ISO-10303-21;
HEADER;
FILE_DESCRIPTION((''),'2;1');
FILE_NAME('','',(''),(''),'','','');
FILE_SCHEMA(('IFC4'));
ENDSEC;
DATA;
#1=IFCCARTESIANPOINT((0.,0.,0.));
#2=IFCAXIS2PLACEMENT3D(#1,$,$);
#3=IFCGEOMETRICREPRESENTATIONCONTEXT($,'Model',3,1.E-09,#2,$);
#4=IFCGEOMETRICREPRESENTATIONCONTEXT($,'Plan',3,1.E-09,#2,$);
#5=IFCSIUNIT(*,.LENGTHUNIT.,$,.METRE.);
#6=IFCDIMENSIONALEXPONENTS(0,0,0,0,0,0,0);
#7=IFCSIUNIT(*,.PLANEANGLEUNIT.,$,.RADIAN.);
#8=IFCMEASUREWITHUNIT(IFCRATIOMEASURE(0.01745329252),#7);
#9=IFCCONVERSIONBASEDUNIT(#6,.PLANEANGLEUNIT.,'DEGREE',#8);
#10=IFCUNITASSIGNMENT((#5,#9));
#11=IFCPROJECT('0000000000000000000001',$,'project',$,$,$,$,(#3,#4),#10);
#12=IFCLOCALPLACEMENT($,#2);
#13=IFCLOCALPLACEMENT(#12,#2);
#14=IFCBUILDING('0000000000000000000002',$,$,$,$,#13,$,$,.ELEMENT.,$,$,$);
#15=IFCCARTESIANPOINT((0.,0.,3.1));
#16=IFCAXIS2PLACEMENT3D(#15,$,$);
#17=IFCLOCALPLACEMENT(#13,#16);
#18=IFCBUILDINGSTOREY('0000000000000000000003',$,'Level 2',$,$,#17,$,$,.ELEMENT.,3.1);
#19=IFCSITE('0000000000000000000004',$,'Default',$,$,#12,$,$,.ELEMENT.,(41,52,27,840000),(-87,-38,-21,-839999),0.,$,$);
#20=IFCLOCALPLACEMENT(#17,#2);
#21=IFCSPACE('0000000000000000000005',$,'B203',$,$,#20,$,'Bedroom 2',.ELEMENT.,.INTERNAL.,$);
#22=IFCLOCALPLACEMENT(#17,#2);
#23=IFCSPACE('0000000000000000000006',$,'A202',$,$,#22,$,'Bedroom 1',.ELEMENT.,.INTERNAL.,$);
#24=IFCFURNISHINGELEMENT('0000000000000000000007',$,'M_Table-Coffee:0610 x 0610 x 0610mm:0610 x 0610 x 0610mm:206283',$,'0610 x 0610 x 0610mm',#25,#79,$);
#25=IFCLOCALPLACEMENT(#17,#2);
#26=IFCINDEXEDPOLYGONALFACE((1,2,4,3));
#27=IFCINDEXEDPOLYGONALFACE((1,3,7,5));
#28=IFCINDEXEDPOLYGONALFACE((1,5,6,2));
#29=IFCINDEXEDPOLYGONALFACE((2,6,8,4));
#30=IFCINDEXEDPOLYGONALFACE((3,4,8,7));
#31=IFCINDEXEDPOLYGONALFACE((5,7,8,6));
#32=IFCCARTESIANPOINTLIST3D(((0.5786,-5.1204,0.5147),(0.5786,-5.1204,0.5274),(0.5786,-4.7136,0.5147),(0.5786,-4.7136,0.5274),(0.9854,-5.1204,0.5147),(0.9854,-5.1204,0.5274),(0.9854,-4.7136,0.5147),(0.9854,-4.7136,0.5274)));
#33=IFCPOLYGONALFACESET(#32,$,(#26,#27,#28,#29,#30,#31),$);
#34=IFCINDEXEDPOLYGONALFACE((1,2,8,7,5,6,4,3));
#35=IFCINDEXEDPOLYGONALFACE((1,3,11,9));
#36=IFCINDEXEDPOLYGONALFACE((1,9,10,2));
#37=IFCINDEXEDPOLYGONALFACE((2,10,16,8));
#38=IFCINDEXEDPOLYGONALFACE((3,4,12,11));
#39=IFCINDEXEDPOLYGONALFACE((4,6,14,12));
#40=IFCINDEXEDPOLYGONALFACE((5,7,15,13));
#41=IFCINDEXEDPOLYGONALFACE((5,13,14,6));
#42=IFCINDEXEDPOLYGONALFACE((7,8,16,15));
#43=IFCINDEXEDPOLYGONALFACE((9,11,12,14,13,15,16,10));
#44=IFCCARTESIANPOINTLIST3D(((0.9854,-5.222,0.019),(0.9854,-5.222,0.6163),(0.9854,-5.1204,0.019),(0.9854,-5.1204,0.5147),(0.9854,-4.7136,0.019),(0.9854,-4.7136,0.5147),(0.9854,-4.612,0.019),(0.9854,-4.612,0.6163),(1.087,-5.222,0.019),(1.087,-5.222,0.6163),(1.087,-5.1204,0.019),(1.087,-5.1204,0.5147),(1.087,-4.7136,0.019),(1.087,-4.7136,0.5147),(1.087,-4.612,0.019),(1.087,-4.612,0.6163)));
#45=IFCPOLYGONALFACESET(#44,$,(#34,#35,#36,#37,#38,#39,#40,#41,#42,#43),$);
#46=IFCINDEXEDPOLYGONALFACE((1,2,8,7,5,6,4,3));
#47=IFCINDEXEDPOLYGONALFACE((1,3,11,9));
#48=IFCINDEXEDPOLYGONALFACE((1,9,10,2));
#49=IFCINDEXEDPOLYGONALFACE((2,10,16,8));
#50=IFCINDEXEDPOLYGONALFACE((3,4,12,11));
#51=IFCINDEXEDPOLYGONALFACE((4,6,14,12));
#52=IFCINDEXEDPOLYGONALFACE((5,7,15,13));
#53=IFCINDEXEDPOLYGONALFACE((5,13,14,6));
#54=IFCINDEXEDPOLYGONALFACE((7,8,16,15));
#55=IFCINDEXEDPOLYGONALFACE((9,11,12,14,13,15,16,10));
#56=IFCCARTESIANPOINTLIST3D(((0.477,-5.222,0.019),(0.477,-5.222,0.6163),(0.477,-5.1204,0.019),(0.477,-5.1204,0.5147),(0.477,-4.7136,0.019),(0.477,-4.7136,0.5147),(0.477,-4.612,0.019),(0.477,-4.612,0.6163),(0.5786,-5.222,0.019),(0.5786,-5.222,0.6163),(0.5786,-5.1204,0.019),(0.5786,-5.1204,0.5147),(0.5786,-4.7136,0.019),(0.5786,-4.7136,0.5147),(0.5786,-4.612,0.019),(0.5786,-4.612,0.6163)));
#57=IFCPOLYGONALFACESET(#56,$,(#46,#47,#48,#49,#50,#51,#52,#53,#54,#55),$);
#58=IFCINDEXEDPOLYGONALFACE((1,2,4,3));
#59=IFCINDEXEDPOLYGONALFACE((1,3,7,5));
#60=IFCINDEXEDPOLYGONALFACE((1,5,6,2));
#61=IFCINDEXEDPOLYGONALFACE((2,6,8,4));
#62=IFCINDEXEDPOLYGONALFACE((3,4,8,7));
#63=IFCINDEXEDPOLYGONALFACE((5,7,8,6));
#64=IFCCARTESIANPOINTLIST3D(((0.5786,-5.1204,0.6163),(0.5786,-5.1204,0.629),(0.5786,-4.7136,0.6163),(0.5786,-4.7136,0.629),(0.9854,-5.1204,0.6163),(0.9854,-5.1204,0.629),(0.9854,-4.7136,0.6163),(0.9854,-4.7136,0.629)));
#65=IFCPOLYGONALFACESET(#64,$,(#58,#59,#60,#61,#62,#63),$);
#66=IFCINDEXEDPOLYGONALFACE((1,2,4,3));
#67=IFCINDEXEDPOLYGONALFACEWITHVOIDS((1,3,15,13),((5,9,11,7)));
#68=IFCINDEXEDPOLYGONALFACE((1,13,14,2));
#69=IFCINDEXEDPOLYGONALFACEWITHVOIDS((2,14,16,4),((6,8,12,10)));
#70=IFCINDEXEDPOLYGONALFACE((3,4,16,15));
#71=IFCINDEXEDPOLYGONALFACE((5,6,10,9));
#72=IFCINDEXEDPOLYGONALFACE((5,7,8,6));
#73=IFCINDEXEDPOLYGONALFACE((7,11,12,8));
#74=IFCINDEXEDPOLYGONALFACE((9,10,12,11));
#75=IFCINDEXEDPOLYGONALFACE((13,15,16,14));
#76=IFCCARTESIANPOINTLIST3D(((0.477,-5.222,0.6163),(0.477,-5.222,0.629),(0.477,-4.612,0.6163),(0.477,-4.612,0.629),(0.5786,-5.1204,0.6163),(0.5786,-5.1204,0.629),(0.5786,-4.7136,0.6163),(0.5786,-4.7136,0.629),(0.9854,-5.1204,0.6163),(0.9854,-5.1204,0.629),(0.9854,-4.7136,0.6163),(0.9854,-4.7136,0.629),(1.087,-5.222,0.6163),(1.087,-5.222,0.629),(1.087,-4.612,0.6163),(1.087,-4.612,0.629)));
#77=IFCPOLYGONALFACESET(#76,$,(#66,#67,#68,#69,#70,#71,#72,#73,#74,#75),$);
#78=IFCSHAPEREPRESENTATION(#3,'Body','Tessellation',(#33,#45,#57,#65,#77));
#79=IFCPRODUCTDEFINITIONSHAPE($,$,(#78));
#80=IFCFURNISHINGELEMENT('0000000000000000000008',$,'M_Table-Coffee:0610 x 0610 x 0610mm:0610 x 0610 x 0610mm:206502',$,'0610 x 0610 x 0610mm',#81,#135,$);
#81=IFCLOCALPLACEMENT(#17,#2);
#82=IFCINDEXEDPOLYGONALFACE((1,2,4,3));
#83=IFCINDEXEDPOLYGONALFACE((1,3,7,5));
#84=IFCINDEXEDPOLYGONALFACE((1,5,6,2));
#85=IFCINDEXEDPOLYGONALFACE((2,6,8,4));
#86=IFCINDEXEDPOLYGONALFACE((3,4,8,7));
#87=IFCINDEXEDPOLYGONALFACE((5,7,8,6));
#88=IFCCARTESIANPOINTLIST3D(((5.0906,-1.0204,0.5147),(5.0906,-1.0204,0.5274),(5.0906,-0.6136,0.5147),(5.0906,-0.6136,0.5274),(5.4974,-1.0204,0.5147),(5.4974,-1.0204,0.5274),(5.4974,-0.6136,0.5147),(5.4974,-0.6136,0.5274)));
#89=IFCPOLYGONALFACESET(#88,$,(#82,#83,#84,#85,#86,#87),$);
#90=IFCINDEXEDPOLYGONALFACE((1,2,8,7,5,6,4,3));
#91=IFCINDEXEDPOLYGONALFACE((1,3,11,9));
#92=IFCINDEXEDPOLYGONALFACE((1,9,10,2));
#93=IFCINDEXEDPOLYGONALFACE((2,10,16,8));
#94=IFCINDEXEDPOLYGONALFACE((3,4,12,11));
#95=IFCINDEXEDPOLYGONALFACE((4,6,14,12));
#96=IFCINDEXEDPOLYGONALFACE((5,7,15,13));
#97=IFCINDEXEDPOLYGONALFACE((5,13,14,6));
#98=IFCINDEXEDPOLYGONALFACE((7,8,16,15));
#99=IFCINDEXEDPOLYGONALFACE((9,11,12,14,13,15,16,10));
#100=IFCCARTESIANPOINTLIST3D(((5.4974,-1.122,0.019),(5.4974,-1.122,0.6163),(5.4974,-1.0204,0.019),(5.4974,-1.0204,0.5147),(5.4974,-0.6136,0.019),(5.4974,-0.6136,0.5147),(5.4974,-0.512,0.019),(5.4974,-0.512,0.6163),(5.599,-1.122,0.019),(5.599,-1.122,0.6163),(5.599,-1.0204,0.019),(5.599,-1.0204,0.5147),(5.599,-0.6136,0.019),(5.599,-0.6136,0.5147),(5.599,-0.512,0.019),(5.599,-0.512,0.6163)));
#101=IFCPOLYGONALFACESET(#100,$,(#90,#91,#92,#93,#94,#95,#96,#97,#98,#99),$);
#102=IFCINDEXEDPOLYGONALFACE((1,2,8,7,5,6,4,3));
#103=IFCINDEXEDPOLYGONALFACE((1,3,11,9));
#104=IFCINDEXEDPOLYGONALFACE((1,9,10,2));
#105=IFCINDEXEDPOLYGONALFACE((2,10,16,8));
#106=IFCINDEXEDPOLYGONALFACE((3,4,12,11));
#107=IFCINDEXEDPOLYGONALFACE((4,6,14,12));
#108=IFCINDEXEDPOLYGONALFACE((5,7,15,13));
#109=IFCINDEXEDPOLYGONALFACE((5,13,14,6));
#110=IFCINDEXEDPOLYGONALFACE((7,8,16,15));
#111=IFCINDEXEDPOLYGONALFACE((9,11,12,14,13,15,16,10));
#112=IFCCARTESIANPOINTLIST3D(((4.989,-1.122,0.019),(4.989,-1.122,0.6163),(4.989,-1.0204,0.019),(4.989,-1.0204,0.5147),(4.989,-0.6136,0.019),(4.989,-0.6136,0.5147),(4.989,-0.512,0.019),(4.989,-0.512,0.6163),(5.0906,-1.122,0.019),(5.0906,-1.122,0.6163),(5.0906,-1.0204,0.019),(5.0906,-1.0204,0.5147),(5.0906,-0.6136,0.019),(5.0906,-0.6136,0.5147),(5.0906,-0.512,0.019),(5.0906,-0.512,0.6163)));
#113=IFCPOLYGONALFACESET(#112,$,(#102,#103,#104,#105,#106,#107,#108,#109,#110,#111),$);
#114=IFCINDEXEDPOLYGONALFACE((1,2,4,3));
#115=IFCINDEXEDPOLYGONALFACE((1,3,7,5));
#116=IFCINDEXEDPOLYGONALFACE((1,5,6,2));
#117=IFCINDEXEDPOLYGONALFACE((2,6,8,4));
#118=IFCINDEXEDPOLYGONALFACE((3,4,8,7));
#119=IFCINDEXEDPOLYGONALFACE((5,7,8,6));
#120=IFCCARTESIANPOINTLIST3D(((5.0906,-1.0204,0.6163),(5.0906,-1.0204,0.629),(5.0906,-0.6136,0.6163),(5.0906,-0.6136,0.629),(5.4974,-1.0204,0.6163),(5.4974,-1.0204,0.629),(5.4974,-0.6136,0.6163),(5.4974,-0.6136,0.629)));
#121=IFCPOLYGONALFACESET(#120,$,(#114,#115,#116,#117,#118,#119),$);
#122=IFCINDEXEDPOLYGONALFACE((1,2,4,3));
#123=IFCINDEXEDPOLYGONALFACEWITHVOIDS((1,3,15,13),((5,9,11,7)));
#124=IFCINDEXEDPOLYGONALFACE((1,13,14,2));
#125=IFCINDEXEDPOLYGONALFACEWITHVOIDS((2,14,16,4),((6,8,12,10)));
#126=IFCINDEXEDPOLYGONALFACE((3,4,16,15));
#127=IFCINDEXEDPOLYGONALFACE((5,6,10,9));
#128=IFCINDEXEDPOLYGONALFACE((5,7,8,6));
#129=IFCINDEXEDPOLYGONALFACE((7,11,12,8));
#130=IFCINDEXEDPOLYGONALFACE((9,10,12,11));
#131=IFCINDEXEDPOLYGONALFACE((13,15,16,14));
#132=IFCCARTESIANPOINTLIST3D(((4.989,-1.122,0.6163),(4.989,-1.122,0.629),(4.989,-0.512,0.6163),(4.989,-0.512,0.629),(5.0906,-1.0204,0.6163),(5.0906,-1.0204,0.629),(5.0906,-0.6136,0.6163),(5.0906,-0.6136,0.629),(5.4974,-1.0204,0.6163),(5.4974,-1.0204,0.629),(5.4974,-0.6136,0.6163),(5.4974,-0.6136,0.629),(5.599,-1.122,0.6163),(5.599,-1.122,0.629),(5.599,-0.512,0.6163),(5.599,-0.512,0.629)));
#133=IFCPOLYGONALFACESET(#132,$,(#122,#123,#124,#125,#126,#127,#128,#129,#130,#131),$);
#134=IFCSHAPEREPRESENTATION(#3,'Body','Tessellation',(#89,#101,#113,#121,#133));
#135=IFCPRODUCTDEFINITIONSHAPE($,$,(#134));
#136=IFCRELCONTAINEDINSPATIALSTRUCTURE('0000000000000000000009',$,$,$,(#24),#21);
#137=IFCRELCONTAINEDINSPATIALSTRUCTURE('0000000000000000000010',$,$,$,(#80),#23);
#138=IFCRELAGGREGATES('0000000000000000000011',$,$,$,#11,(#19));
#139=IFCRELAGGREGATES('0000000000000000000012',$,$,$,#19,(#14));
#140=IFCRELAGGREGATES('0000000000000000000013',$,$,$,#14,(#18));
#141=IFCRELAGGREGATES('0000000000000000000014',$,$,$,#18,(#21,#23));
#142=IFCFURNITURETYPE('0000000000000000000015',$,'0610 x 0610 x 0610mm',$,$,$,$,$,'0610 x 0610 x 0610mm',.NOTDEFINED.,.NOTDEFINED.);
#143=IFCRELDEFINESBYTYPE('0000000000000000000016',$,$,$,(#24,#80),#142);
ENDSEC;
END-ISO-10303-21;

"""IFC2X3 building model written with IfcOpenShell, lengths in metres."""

from ifc_helpers import new_model, entity, si_unit, converted_unit, frame, origin, origin_2d_with_axis, place, context, project, spatial, polyline, rectangle, outline, extrude, source, transform, mapped, type_object, type_shapes, element, save


model = new_model("IFC2X3")

# Units and contexts
model_context = context("Model", 3, precision=1e-09, world=origin())
plan_context = context("Plan", 3, precision=1e-09, world=origin())
ifc_project = project(units=[si_unit("LENGTHUNIT", "METRE"), converted_unit("PLANEANGLEUNIT", "DEGREE", entity("IfcRatioMeasure", 0.01745329252), si_unit("PLANEANGLEUNIT", "RADIAN"), dimensions=[0, 0, 0, 0, 0, 0, 0])], contexts=[model_context, plan_context])

# Site, building, storey
site_placement = place(None, origin())
site = spatial("IfcSite", under=ifc_project, at=site_placement, Name="Default", CompositionType="ELEMENT", RefLatitude=(41, 52, 27, 840000), RefLongitude=(-87, -38, -21, -839999), RefElevation=0.0)
building_placement = place(site_placement, origin())
building = spatial("IfcBuilding", under=site, at=building_placement, CompositionType="ELEMENT")
storey_placement = place(building_placement, frame((0.0, 0.0, 3.1)))
storey = spatial("IfcBuildingStorey", under=building, at=storey_placement, Name="Level 2", CompositionType="ELEMENT", Elevation=3.1)

# Shared definitions
space_1_placement = place(storey_placement, origin())
space_1 = spatial("IfcSpace", under=storey, at=space_1_placement, Name="B203", LongName="Bedroom 2", CompositionType="ELEMENT", InteriorOrExteriorSpace="INTERNAL")

# Furnishing element
furniture_type = type_object("IfcFurnitureType", Name="0610 x 0610 x 0610mm", ElementType="0610 x 0610 x 0610mm", AssemblyPlace="NOTDEFINED")
shared_shape_1 = source(origin(), model_context, "Body", "SweptSolid", [
    extrude(rectangle(XDim=0.4068, YDim=0.4068, at=origin_2d_with_axis()), frame((0.0183, 0.0952, 0.4957), z_axis=(0.0, 0.0, 1.0), x_axis=(-1.0, 0.0, 0.0)), (0.0, 0.0, 1.0), 0.0127),
    extrude(outline(polyline([(-0.2732, -0.305), (0.3241, -0.305), (0.3241, 0.305), (-0.2732, 0.305), (-0.2732, 0.2034), (0.2225, 0.2034), (0.2225, -0.2034), (-0.2732, -0.2034), (-0.2732, -0.305)])), frame((0.2217, 0.0952, 0.2732), z_axis=(1.0, 0.0, 0.0), x_axis=(0.0, 0.0, 1.0)), (0.0, 0.0, 1.0), 0.1016),
    extrude(outline(polyline([(-0.305, -0.3241), (0.305, -0.3241), (0.305, 0.2732), (0.2034, 0.2732), (0.2034, -0.2225), (-0.2034, -0.2225), (-0.2034, 0.2732), (-0.305, 0.2732), (-0.305, -0.3241)])), frame((-0.2867, 0.0952, 0.2732), z_axis=(1.0, 0.0, 0.0), x_axis=(0.0, -1.0, 0.0)), (0.0, 0.0, 1.0), 0.1016),
    extrude(rectangle(XDim=0.4068, YDim=0.4068, at=origin_2d_with_axis()), frame((0.0183, 0.0952, 0.5973), z_axis=(0.0, 0.0, 1.0), x_axis=(-1.0, 0.0, 0.0)), (0.0, 0.0, 1.0), 0.0127),
    extrude(outline(polyline([(-0.305, -0.305), (0.305, -0.305), (0.305, 0.305), (-0.305, 0.305), (-0.305, -0.305)]), holes=[polyline([(-0.2034, -0.2034), (-0.2034, 0.2034), (0.2034, 0.2034), (0.2034, -0.2034), (-0.2034, -0.2034)])]), frame((0.0183, 0.0952, 0.5973), z_axis=(0.0, 0.0, 1.0), x_axis=(-1.0, 0.0, 0.0)), (0.0, 0.0, 1.0), 0.0127),
])
type_shapes(furniture_type, [shared_shape_1])
furnishing_1_placement = place(space_1_placement, frame((0.7637, -5.0122, 0.019)))
element("IfcFurnishingElement", 1, at=furnishing_1_placement, inside=space_1, type_object=furniture_type, Name="M_Table-Coffee:0610 x 0610 x 0610mm:0610 x 0610 x 0610mm:206283", ObjectType="0610 x 0610 x 0610mm", context=model_context, shape_type="MappedRepresentation", body=[
    mapped(shared_shape_1, transform((0.0, 0.0, 0.0), scale=1.0)),
])

# Shared definitions
space_2_placement = place(storey_placement, origin())
space_2 = spatial("IfcSpace", under=storey, at=space_2_placement, Name="A202", LongName="Bedroom 1", CompositionType="ELEMENT", InteriorOrExteriorSpace="INTERNAL")

# Furnishing element
furnishing_2_placement = place(space_2_placement, frame((5.2757, -0.9122, 0.019)))
element("IfcFurnishingElement", 2, at=furnishing_2_placement, inside=space_2, type_object=furniture_type, Name="M_Table-Coffee:0610 x 0610 x 0610mm:0610 x 0610 x 0610mm:206502", ObjectType="0610 x 0610 x 0610mm", context=model_context, shape_type="MappedRepresentation", body=[
    mapped(shared_shape_1, transform((0.0, 0.0, 0.0), scale=1.0)),
])

save(model, "model.ifc")
